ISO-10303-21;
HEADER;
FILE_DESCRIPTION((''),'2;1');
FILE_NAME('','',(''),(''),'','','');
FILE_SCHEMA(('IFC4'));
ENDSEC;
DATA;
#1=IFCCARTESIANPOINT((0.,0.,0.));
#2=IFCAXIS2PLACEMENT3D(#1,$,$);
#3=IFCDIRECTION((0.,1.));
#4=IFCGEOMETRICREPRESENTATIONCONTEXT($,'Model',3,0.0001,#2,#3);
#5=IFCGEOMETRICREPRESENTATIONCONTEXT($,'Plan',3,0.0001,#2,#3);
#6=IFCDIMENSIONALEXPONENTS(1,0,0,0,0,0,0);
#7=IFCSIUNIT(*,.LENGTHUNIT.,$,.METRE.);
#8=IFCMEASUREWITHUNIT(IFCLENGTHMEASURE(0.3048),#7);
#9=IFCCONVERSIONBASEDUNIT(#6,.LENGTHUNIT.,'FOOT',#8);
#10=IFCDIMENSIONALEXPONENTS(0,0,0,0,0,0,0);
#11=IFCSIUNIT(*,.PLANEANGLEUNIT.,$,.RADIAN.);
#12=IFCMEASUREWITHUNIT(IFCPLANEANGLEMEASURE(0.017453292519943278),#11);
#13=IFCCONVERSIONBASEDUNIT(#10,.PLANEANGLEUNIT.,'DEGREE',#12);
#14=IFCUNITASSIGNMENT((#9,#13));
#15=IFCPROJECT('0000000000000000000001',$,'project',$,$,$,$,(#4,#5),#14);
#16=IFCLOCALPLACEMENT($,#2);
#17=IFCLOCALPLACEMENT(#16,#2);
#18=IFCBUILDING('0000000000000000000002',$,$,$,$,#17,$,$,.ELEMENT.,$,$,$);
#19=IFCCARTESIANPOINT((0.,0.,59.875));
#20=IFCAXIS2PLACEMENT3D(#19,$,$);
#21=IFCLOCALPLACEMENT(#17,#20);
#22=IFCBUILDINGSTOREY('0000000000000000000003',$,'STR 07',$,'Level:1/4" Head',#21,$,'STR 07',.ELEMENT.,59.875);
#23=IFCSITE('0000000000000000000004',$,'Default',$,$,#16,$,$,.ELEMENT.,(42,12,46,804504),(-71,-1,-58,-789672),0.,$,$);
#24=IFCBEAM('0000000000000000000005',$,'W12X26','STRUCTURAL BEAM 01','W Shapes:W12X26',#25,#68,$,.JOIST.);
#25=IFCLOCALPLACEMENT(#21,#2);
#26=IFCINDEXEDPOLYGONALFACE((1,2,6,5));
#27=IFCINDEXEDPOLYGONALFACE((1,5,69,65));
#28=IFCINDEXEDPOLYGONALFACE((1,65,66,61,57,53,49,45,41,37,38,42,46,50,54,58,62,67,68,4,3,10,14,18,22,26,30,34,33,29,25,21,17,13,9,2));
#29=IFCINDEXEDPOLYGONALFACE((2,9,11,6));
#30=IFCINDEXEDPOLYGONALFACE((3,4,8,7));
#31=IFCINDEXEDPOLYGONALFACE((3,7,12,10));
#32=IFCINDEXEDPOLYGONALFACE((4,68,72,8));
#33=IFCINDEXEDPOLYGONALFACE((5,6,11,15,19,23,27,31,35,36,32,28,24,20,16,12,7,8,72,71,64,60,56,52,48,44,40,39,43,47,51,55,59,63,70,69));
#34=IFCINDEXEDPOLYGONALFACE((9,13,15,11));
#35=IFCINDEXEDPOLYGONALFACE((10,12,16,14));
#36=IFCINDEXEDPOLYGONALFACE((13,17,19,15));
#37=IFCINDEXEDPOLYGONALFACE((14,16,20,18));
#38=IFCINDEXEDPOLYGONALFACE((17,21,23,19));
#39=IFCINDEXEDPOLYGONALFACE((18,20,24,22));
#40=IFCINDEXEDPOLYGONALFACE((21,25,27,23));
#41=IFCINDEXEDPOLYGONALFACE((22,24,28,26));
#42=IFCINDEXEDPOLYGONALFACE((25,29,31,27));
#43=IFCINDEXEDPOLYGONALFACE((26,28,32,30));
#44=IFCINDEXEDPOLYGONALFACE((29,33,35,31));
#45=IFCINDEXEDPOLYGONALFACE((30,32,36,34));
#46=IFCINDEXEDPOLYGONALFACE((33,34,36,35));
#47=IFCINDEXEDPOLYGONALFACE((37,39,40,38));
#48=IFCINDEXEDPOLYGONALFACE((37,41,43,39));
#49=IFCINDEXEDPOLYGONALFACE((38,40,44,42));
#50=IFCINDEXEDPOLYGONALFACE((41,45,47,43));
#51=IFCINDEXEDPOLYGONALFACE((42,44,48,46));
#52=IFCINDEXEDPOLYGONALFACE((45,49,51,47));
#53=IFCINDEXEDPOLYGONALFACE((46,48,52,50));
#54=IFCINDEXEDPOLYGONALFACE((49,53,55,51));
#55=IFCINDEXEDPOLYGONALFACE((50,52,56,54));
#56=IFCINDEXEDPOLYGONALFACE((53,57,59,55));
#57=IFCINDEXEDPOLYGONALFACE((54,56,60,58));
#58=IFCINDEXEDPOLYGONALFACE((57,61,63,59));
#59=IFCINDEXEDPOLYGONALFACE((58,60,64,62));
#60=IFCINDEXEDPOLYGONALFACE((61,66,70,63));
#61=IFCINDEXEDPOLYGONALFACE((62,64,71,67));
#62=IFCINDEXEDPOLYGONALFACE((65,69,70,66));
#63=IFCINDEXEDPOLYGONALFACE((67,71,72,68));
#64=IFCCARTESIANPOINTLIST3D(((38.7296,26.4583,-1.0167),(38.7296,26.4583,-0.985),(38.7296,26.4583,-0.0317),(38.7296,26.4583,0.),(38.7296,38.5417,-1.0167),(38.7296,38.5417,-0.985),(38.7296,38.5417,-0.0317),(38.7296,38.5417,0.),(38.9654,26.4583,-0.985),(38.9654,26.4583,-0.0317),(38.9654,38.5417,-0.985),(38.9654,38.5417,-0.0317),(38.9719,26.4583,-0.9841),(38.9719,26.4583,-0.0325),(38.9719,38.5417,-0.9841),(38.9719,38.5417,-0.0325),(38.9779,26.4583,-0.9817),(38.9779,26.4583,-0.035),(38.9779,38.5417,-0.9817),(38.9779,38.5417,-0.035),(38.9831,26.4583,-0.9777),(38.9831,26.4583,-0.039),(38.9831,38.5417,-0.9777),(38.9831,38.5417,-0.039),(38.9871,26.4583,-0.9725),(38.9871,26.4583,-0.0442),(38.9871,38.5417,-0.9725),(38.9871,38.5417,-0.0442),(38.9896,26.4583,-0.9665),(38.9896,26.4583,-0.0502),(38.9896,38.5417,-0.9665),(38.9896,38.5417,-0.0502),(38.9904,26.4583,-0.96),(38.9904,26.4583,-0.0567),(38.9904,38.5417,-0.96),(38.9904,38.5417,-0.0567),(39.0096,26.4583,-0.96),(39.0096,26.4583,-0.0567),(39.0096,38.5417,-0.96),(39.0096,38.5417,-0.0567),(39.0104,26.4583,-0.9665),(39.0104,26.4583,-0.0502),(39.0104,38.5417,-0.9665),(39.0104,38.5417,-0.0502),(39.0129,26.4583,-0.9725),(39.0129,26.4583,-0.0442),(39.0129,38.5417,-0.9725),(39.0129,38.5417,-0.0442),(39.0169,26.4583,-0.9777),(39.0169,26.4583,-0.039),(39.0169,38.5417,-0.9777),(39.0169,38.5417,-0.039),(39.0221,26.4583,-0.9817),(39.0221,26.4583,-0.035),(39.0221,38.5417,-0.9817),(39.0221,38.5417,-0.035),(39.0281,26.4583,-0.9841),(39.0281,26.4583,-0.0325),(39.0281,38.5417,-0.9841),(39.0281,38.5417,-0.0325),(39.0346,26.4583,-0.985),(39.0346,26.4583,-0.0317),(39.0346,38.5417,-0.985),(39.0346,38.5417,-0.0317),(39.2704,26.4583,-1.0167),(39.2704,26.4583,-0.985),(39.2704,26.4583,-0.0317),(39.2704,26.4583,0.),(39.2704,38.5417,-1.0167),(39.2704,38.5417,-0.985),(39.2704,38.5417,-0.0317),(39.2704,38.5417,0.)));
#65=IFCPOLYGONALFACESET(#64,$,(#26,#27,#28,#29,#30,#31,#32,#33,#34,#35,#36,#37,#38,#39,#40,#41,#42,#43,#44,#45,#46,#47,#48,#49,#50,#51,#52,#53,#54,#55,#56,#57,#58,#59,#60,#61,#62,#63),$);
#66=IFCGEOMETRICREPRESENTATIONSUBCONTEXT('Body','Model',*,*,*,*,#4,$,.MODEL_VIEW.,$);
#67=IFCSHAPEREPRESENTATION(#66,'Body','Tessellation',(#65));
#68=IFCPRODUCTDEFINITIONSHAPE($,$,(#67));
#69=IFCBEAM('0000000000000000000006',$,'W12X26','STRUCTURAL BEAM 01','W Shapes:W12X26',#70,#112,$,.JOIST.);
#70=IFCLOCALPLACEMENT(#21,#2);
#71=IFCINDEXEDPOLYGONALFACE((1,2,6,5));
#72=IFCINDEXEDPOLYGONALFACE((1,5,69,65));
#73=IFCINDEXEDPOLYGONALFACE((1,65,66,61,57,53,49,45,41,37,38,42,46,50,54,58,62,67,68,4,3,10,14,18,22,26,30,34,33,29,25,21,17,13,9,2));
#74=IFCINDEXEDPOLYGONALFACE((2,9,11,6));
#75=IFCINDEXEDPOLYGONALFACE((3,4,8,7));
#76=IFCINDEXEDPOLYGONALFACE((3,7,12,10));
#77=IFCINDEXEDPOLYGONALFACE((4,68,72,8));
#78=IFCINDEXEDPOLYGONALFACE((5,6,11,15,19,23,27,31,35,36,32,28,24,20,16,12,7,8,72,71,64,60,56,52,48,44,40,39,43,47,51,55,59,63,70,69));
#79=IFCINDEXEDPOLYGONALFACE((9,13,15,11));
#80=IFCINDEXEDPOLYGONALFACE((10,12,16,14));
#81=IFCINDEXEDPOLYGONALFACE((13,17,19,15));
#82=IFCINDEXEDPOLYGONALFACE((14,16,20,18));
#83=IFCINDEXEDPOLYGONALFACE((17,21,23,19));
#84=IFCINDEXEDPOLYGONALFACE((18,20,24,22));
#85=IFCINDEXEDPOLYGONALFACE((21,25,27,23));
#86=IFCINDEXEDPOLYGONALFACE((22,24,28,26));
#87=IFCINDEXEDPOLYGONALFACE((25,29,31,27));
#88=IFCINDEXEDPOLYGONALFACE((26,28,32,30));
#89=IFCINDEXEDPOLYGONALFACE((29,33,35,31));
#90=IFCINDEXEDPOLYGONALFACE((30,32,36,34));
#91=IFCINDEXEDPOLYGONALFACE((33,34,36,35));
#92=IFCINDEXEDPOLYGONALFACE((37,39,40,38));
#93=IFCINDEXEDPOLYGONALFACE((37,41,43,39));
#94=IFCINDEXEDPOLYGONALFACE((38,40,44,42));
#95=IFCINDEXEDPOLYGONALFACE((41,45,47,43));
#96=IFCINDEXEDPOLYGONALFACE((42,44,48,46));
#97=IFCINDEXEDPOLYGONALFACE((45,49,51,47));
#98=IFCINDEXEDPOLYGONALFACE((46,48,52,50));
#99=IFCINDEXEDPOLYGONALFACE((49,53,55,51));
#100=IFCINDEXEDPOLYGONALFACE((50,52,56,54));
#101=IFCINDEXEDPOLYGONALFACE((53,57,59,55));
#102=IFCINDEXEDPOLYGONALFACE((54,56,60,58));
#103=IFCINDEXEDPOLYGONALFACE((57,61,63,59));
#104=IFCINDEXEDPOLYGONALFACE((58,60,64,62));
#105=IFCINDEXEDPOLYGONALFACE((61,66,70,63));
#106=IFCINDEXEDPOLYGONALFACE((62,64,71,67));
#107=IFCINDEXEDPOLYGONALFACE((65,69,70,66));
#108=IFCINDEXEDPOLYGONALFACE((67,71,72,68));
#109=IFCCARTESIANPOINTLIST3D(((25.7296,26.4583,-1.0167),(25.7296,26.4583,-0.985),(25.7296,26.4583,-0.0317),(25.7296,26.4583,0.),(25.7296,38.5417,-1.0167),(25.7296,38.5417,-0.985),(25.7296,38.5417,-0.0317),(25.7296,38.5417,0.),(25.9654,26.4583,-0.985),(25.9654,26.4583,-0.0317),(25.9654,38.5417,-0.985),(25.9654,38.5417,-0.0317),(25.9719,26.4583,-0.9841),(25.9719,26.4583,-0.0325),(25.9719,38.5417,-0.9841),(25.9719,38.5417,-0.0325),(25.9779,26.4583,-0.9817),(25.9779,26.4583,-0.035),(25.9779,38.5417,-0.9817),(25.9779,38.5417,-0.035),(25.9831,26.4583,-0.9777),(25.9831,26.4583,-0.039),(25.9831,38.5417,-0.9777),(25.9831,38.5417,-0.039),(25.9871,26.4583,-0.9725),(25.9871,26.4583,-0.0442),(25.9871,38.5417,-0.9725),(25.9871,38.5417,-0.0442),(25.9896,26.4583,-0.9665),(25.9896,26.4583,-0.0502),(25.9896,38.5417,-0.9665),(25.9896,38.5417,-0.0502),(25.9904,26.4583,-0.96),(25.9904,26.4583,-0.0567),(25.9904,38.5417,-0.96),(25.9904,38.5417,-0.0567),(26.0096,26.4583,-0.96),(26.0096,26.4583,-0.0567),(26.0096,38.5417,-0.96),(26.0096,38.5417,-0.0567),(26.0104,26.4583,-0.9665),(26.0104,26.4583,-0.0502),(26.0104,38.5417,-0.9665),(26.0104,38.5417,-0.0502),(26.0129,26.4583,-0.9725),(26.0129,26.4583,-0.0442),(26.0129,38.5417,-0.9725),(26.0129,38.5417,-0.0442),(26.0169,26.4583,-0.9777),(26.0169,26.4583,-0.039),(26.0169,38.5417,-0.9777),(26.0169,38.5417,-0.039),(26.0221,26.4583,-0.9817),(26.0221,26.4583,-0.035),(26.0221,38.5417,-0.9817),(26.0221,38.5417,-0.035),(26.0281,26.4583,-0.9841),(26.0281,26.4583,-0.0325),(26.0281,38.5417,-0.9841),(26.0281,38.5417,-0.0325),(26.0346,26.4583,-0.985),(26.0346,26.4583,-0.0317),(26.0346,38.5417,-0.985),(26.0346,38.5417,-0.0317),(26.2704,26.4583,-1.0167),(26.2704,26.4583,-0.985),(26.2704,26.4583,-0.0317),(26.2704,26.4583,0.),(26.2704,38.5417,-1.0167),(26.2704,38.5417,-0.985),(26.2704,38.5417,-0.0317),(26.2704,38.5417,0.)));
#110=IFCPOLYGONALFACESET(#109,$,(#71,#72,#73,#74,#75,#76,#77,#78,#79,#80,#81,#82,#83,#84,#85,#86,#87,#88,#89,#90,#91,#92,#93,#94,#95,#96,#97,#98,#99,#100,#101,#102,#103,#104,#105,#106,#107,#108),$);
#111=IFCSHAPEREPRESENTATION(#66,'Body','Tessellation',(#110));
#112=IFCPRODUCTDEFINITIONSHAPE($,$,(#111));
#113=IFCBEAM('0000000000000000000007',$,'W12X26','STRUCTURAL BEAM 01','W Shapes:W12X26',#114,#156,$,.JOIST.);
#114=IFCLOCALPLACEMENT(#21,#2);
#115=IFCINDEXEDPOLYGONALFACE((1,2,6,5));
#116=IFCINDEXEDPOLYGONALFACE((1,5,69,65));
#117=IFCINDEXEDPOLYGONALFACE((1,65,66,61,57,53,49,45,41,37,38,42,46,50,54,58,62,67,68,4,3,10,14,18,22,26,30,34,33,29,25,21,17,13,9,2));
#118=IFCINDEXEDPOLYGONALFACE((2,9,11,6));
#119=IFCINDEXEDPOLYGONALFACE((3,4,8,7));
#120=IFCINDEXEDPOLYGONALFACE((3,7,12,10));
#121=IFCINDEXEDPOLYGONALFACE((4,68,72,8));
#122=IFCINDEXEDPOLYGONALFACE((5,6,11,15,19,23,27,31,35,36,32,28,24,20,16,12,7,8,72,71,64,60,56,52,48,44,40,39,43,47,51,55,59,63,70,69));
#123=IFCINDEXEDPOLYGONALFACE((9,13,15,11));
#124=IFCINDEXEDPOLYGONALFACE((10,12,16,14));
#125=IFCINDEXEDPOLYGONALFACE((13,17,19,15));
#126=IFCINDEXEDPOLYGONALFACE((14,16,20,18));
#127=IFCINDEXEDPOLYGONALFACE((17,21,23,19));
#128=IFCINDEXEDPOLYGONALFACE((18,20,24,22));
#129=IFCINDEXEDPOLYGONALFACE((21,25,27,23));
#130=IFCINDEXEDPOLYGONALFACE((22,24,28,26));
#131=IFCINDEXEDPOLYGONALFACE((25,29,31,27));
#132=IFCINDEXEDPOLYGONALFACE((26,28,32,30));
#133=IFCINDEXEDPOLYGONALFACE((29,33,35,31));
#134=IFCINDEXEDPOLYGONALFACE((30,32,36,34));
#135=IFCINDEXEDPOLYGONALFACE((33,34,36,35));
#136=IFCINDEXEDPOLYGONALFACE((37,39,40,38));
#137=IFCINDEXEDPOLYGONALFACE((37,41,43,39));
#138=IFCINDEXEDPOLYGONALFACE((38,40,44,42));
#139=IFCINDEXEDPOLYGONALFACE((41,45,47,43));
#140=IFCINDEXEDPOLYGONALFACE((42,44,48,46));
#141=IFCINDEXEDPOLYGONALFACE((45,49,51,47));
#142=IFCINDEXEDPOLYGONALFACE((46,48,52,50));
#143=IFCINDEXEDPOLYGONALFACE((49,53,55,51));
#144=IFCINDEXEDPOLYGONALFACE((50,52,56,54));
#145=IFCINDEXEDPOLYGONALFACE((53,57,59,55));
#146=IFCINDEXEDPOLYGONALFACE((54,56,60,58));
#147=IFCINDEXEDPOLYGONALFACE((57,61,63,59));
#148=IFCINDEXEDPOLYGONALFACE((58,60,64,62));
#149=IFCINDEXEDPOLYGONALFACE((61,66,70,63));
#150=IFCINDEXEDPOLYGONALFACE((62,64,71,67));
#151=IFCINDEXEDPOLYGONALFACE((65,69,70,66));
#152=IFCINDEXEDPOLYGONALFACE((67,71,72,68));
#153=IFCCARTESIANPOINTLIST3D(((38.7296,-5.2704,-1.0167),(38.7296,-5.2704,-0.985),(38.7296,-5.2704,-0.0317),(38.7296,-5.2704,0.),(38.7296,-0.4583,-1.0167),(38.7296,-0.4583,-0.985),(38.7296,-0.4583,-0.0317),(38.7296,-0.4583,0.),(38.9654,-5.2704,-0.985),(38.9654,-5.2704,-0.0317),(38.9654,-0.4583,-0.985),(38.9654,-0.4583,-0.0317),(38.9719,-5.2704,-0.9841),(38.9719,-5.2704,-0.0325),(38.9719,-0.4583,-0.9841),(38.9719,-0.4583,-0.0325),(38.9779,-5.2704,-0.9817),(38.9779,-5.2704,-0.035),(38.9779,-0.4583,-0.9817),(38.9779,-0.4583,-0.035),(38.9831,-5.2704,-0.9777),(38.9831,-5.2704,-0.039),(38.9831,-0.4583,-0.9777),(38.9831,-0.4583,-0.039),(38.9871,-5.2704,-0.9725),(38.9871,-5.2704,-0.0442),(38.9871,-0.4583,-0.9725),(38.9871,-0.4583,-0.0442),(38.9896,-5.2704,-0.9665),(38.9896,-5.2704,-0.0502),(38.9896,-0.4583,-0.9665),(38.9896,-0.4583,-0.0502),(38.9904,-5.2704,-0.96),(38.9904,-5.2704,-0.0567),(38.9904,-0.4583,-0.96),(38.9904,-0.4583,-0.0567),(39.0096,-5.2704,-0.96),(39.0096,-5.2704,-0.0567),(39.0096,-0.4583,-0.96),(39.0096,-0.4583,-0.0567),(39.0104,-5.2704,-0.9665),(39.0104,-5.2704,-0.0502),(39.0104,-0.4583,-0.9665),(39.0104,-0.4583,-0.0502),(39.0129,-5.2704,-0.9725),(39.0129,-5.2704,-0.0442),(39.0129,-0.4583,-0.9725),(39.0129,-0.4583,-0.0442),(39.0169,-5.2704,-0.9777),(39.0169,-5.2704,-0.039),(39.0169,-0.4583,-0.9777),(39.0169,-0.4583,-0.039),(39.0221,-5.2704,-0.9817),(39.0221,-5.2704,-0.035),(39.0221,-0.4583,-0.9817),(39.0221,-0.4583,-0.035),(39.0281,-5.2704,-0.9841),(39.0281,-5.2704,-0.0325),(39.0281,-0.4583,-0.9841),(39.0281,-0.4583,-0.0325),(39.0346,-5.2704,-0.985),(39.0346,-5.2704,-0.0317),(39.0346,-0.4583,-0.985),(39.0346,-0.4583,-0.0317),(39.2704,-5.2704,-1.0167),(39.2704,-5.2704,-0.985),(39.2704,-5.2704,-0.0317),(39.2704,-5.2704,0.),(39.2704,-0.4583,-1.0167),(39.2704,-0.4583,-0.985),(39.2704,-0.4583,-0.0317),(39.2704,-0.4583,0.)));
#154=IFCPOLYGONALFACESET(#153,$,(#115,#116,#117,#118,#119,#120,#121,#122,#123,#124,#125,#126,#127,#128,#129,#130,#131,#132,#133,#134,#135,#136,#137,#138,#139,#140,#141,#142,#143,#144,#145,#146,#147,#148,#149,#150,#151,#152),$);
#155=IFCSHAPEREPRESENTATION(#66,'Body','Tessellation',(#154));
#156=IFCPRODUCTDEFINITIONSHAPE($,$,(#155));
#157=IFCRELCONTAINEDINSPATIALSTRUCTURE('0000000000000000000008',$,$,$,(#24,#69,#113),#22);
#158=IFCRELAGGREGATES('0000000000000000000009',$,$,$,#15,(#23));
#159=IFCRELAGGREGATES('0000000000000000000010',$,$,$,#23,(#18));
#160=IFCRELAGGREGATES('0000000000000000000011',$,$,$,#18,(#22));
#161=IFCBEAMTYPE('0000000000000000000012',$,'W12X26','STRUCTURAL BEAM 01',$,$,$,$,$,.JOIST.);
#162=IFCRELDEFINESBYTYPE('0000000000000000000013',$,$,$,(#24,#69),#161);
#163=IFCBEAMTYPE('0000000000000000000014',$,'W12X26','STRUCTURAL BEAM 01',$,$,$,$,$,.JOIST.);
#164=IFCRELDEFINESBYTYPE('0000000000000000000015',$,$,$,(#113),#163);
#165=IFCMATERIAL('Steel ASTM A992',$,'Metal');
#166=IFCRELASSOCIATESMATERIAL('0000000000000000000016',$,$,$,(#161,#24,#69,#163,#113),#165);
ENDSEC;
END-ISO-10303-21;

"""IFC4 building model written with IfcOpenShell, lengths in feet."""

from ifc_helpers import new_model, entity, si_unit, converted_unit, direction, frame, origin, place, context, subcontext, project, spatial, line, arc, indexed_curve, outline, extrude, source, transform, mapped, material, type_object, type_shapes, element, save


model = new_model("IFC4")

# Units and contexts
model_context = context("Model", 3, precision=0.0001, world=origin(), true_north=direction((0.0, 1.0)))
plan_context = context("Plan", 3, precision=0.0001, world=origin(), true_north=direction((0.0, 1.0)))
body_context = subcontext(model_context, "Body", "Model", "MODEL_VIEW")
ifc_project = project(units=[converted_unit("LENGTHUNIT", "FOOT", entity("IfcLengthMeasure", 0.3048), si_unit("LENGTHUNIT", "METRE"), dimensions=[1, 0, 0, 0, 0, 0, 0]), converted_unit("PLANEANGLEUNIT", "DEGREE", entity("IfcPlaneAngleMeasure", 0.017453292519943278), si_unit("PLANEANGLEUNIT", "RADIAN"), dimensions=[0, 0, 0, 0, 0, 0, 0])], contexts=[model_context, plan_context])

# Site, building, storey
site_placement = place(None, origin())
site = spatial("IfcSite", under=ifc_project, at=site_placement, Name="Default", CompositionType="ELEMENT", RefLatitude=(42, 12, 46, 804504), RefLongitude=(-71, -1, -58, -789672), RefElevation=0.0)
building_placement = place(site_placement, origin())
building = spatial("IfcBuilding", under=site, at=building_placement, CompositionType="ELEMENT")
storey_placement = place(building_placement, frame((0.0, 0.0, 59.875)))
storey = spatial("IfcBuildingStorey", under=building, at=storey_placement, Name="STR 07", ObjectType="Level:1/4\" Head", LongName="STR 07", CompositionType="ELEMENT", Elevation=59.875)

# Shared definitions
ifc_material = material(Name="Steel ASTM A992", Category="Metal")

# Beams
beam_type_1 = type_object("IfcBeamType", Name="W12X26", Description="STRUCTURAL BEAM 01", PredefinedType="JOIST", material=ifc_material)
shared_shape_1 = source(origin(), body_context, "Body", "SweptSolid", [
    extrude(outline(indexed_curve([(-0.2704, -0.4767), (-0.2704, -0.5083), (0.2704, -0.5083), (0.2704, -0.4767), (0.0346, -0.4767), (0.0169, -0.4693), (0.0096, -0.4517), (0.0096, 0.4517), (0.0169, 0.4693), (0.0346, 0.4767), (0.2704, 0.4767), (0.2704, 0.5083), (-0.2704, 0.5083), (-0.2704, 0.4767), (-0.0346, 0.4767), (-0.0169, 0.4693), (-0.0096, 0.4517), (-0.0096, -0.4517), (-0.0169, -0.4693), (-0.0346, -0.4767)], segments=[line(1, 2, 3, 4, 5), arc(5, 6, 7), line(7, 8), arc(8, 9, 10), line(10, 11, 12, 13, 14, 15), arc(15, 16, 17), line(17, 18), arc(18, 19, 20), line(20, 1)], self_intersect=False)), frame((-6.165, 0.0, 0.0), z_axis=(-1.0, 0.0, 0.0), x_axis=(0.0, -1.0, 0.0)), (0.0, 0.0, -1.0), 12.0833),
])
type_shapes(beam_type_1, [shared_shape_1])
for number, where, z_axis, x_axis, name in (
    (1, (39.0, 32.6234, -0.5083), (0.0, 0.0, 1.0), (0.0, 1.0, 0.0), "W12X26"),
    (2, (26.0, 32.6234, -0.5083), (0.0, 0.0, 1.0), (0.0, 1.0, 0.0), "W12X26"),
):
    element("IfcBeam", number, at=place(storey_placement, frame(where, z_axis=z_axis, x_axis=x_axis)), inside=storey, type_object=beam_type_1, material=ifc_material, Name=name, Description="STRUCTURAL BEAM 01", ObjectType="W Shapes:W12X26", PredefinedType="JOIST", context=body_context, shape_type="MappedRepresentation", body=[
        mapped(shared_shape_1, transform((0.0, 0.0, 0.0), scale=1.0)),
    ])
beam_type_2 = type_object("IfcBeamType", Name="W12X26", Description="STRUCTURAL BEAM 01", PredefinedType="JOIST", material=ifc_material)
shared_shape_2 = source(origin(), body_context, "Body", "SweptSolid", [
    extrude(outline(indexed_curve([(0.4767, -0.2704), (0.5083, -0.2704), (0.5083, 0.2704), (0.4767, 0.2704), (0.4767, 0.0346), (0.4693, 0.0169), (0.4517, 0.0096), (-0.4517, 0.0096), (-0.4693, 0.0169), (-0.4767, 0.0346), (-0.4767, 0.2704), (-0.5083, 0.2704), (-0.5083, -0.2704), (-0.4767, -0.2704), (-0.4767, -0.0346), (-0.4693, -0.0169), (-0.4517, -0.0096), (0.4517, -0.0096), (0.4693, -0.0169), (0.4767, -0.0346)], segments=[line(1, 2, 3, 4, 5), arc(5, 6, 7), line(7, 8), arc(8, 9, 10), line(10, 11, 12, 13, 14, 15), arc(15, 16, 17), line(17, 18), arc(18, 19, 20), line(20, 1)], self_intersect=False)), frame((-2.0417, 0.0, 0.0), z_axis=(1.0, 0.0, 0.0), x_axis=(0.0, 0.0, -1.0)), (0.0, 0.0, 1.0), 4.8121),
])
type_shapes(beam_type_2, [shared_shape_2])
for number, where, z_axis, x_axis, name in (
    (3, (39.0, -2.5, -0.5083), (0.0, 0.0, 1.0), (0.0, -1.0, 0.0), "W12X26"),
):
    element("IfcBeam", number, at=place(storey_placement, frame(where, z_axis=z_axis, x_axis=x_axis)), inside=storey, type_object=beam_type_2, material=ifc_material, Name=name, Description="STRUCTURAL BEAM 01", ObjectType="W Shapes:W12X26", PredefinedType="JOIST", context=body_context, shape_type="MappedRepresentation", body=[
        mapped(shared_shape_2, transform((0.0, 0.0, 0.0), scale=1.0)),
    ])

save(model, "model.ifc")
